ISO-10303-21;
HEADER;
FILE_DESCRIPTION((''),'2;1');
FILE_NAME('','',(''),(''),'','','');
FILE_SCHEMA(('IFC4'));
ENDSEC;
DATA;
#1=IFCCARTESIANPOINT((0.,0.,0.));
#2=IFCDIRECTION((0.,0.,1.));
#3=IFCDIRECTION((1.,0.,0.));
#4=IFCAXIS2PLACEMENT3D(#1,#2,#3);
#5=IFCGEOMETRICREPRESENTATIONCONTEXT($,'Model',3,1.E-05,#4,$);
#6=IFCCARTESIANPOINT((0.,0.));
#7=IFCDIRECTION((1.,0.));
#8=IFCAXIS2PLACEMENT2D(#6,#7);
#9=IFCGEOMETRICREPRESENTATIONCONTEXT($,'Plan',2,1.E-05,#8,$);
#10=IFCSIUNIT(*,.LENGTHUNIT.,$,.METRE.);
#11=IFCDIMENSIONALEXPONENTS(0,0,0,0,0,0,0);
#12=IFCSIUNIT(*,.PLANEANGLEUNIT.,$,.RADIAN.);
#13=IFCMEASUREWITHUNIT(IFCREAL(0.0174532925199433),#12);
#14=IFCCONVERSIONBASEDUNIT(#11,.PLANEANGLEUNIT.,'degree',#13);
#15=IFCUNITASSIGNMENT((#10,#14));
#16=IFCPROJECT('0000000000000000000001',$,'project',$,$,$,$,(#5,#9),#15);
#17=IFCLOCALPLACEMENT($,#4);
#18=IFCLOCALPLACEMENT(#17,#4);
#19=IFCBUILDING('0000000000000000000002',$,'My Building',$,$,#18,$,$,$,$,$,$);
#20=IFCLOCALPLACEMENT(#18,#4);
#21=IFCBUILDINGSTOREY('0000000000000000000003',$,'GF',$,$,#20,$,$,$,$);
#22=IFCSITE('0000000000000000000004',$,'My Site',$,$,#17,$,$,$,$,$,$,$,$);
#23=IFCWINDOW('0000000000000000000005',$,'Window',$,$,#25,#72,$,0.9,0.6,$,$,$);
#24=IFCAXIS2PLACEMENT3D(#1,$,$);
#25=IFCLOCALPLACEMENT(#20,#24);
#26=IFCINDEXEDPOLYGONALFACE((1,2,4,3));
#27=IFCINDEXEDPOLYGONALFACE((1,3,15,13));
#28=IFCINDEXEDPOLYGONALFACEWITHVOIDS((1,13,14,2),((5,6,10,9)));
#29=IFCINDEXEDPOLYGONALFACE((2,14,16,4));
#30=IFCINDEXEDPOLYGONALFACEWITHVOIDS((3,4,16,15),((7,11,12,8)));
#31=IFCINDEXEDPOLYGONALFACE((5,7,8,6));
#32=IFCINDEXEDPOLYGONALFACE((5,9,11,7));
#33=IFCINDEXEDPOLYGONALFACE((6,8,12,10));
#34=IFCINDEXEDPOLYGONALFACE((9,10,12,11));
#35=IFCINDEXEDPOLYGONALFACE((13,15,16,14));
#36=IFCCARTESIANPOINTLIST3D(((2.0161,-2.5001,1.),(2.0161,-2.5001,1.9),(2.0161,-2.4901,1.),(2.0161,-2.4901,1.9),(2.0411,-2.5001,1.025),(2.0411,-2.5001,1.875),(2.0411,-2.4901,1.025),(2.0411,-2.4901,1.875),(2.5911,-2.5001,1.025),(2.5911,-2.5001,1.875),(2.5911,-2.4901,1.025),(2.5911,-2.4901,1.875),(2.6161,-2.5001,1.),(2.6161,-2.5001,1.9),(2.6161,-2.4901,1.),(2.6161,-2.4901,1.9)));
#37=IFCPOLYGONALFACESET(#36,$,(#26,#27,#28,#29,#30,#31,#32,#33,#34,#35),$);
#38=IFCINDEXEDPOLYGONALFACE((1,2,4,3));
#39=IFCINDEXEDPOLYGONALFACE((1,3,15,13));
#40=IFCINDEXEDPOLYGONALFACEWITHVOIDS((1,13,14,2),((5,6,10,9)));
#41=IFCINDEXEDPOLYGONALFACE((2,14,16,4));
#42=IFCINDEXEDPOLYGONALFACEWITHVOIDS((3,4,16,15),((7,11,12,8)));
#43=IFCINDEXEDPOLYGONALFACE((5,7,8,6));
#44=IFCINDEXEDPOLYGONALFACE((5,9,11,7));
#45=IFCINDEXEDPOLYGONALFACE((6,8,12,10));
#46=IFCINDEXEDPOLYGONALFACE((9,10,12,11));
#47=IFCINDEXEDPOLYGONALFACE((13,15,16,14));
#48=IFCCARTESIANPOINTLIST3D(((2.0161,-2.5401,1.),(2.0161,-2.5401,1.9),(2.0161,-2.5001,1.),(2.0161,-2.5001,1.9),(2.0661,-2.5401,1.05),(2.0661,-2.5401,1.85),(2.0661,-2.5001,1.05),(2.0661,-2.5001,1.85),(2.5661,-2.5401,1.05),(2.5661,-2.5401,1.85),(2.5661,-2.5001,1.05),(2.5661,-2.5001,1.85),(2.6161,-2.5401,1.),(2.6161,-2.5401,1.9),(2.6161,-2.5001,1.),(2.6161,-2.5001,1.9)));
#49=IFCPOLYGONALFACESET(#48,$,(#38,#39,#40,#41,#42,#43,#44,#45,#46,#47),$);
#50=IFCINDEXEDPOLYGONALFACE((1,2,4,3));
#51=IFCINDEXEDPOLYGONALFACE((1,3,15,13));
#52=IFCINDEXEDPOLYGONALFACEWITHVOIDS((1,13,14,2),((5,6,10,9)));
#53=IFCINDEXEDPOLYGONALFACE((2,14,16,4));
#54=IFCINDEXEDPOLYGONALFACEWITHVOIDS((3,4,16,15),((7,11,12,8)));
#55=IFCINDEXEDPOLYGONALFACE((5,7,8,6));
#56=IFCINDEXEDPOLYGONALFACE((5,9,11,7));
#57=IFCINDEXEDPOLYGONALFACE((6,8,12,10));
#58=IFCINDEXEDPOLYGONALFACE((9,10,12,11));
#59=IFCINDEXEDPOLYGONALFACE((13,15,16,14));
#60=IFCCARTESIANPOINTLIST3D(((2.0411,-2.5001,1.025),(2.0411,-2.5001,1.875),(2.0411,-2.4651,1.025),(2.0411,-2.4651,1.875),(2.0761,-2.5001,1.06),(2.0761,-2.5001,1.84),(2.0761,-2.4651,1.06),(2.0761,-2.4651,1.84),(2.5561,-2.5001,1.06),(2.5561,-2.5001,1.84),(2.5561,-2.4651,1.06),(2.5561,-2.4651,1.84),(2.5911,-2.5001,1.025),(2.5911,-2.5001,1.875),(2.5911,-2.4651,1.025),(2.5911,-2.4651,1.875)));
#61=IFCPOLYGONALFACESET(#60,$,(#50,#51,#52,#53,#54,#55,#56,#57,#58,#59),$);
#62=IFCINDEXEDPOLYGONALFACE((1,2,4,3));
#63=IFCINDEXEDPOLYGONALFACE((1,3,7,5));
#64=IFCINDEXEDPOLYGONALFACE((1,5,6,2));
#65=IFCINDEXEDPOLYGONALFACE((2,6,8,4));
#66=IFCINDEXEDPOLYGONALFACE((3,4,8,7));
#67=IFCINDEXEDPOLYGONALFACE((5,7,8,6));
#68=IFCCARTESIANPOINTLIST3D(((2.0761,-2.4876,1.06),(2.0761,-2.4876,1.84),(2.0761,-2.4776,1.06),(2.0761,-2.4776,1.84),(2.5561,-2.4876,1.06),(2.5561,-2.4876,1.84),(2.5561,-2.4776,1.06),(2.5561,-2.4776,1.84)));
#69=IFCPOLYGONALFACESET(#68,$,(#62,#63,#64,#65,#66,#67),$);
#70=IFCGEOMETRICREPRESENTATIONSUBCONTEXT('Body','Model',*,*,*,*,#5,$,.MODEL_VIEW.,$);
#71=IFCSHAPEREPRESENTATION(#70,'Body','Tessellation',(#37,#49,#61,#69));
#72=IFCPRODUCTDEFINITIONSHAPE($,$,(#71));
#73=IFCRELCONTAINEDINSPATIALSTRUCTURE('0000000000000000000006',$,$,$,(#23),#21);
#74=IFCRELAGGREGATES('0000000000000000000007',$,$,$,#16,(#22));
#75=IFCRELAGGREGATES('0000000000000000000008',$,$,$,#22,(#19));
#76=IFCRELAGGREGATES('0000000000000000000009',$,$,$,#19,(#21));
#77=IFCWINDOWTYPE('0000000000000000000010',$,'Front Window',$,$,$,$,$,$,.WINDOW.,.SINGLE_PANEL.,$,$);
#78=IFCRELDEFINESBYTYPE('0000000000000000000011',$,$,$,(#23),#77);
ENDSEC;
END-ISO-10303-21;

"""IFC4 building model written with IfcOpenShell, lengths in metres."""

from ifc_helpers import new_model, entity, si_unit, converted_unit, frame, origin_with_axes, origin_2d_with_axis, place, context, subcontext, project, spatial, line, indexed_curve, outline, extrude, shape, source, transform, mapped, type_object, type_shapes, element, save


model = new_model("IFC4")

# Units and contexts
model_context = context("Model", 3, precision=1e-05, world=origin_with_axes())
plan_context = context("Plan", 2, precision=1e-05, world=origin_2d_with_axis())
body_context_1 = subcontext(model_context, "Body", "Model", "MODEL_VIEW")
body_context_2 = subcontext(plan_context, "Body", "Plan", "PLAN_VIEW")
ifc_project = project(units=[si_unit("LENGTHUNIT", "METRE"), converted_unit("PLANEANGLEUNIT", "degree", entity("IfcReal", 0.0174532925199433), si_unit("PLANEANGLEUNIT", "RADIAN"), dimensions=[0, 0, 0, 0, 0, 0, 0])], contexts=[model_context, plan_context])

# Site, building, storey
site_placement = place(None, origin_with_axes())
site = spatial("IfcSite", under=ifc_project, at=site_placement, Name="My Site")
building_placement = place(site_placement, origin_with_axes())
building = spatial("IfcBuilding", under=site, at=building_placement, Name="My Building")
storey_placement = place(building_placement, origin_with_axes())
storey = spatial("IfcBuildingStorey", under=building, at=storey_placement, Name="GF")

# Shared definitions
window_type_1 = type_object("IfcWindowType", Name="Front Window", PartitioningType="SINGLE_PANEL", PredefinedType="WINDOW")
shared_shape_1 = source(origin_with_axes(), body_context_1, "Body", "SweptSolid", [
    extrude(outline(indexed_curve([(0.0, 0.0), (0.6, 0.0), (0.6, 0.9), (0.0, 0.9)], segments=[line(1, 2, 3, 4, 1)]), holes=[indexed_curve([(0.025, 0.025), (0.575, 0.025), (0.575, 0.875), (0.025, 0.875)], segments=[line(1, 2, 3, 4, 1)])]), frame((0.0, 0.09, 0.0), z_axis=(0.0, -1.0, 0.0), x_axis=(1.0, 0.0, 0.0)), (0.0, 0.0, -1.0), 0.01),
    extrude(outline(indexed_curve([(0.0, 0.0), (0.6, 0.0), (0.6, 0.9), (0.0, 0.9)], segments=[line(1, 2, 3, 4, 1)]), holes=[indexed_curve([(0.05, 0.05), (0.55, 0.05), (0.55, 0.85), (0.05, 0.85)], segments=[line(1, 2, 3, 4, 1)])]), frame((0.0, 0.05, 0.0), z_axis=(0.0, -1.0, 0.0), x_axis=(1.0, 0.0, 0.0)), (0.0, 0.0, -1.0), 0.04),
    extrude(outline(indexed_curve([(0.0, 0.0), (0.55, 0.0), (0.55, 0.85), (0.0, 0.85)], segments=[line(1, 2, 3, 4, 1)]), holes=[indexed_curve([(0.035, 0.035), (0.515, 0.035), (0.515, 0.815), (0.035, 0.815)], segments=[line(1, 2, 3, 4, 1)])]), frame((0.025, 0.09, 0.025), z_axis=(0.0, -1.0, 0.0), x_axis=(1.0, 0.0, 0.0)), (0.0, 0.0, -1.0), 0.035),
    extrude(outline(indexed_curve([(0.035, 0.035), (0.515, 0.035), (0.515, 0.815), (0.035, 0.815)], segments=[line(1, 2, 3, 4, 1)])), frame((0.025, 0.1025, 0.025), z_axis=(0.0, -1.0, 0.0), x_axis=(1.0, 0.0, 0.0)), (0.0, 0.0, -1.0), 0.01),
])
shared_shape_2 = source(origin_with_axes(), body_context_2, "Body", "Curve2D", [
    entity("IfcIndexedPolyCurve", entity("IfcCartesianPointList2D", [[0.05, 0.05], [0.55, 0.05]])),
    entity("IfcIndexedPolyCurve", entity("IfcCartesianPointList2D", [[0.0, 0.1], [0.025, 0.1], [0.025, 0.09], [0.05, 0.09], [0.05, 0.05], [0.0, 0.05]]), [entity("IfcLineIndex", [1, 2, 3, 4, 5, 6, 1])]),
    entity("IfcIndexedPolyCurve", entity("IfcCartesianPointList2D", [[0.6, 0.1], [0.575, 0.1], [0.575, 0.09], [0.55, 0.09], [0.55, 0.05], [0.6, 0.05]]), [entity("IfcLineIndex", [1, 2, 3, 4, 5, 6, 1])]),
    entity("IfcIndexedPolyCurve", entity("IfcCartesianPointList2D", [[0.025, 0.09], [0.06, 0.09], [0.06, 0.125], [0.025, 0.125]]), [entity("IfcLineIndex", [1, 2, 3, 4, 1])]),
    entity("IfcIndexedPolyCurve", entity("IfcCartesianPointList2D", [[0.575, 0.09], [0.54, 0.09], [0.54, 0.125], [0.575, 0.125]]), [entity("IfcLineIndex", [1, 2, 3, 4, 1])]),
    entity("IfcIndexedPolyCurve", entity("IfcCartesianPointList2D", [[0.06, 0.09], [0.54, 0.09]])),
    entity("IfcIndexedPolyCurve", entity("IfcCartesianPointList2D", [[0.06, 0.125], [0.54, 0.125]])),
    entity("IfcIndexedPolyCurve", entity("IfcCartesianPointList2D", [[0.06, 0.1075], [0.54, 0.1075]])),
])
type_shapes(window_type_1, [shared_shape_1, shared_shape_2])

# Shared definitions
placement_1 = place(storey_placement, frame((0.2266, -2.5901, 0.0), z_axis=(0.0, 0.0, 1.0), x_axis=(1.0, 0.0, 0.0)))

# Window
placement_2 = place(placement_1, frame((1.7895, 0.0, 1.0), z_axis=(0.0, 0.0, 1.0), x_axis=(1.0, 0.0, 0.0)))
window_1_placement = place(placement_2, origin_with_axes())
element("IfcWindow", 1, at=window_1_placement, inside=storey, type_object=window_type_1, Name="Window", OverallHeight=0.9, OverallWidth=0.6, shapes=[
    shape(body_context_1, "Body", "MappedRepresentation", [mapped(shared_shape_1, transform((0.0, 0.0, 0.0), x_axis=(1.0, 0.0, 0.0), y_axis=(0.0, 1.0, 0.0), z_axis=(0.0, 0.0, 1.0), scale=1.0))]),
    shape(body_context_2, "Body", "MappedRepresentation", [mapped(shared_shape_2, transform((0.0, 0.0, 0.0), x_axis=(1.0, 0.0, 0.0), y_axis=(0.0, 1.0, 0.0), z_axis=(0.0, 0.0, 1.0), scale=1.0))]),
])

save(model, "model.ifc")
